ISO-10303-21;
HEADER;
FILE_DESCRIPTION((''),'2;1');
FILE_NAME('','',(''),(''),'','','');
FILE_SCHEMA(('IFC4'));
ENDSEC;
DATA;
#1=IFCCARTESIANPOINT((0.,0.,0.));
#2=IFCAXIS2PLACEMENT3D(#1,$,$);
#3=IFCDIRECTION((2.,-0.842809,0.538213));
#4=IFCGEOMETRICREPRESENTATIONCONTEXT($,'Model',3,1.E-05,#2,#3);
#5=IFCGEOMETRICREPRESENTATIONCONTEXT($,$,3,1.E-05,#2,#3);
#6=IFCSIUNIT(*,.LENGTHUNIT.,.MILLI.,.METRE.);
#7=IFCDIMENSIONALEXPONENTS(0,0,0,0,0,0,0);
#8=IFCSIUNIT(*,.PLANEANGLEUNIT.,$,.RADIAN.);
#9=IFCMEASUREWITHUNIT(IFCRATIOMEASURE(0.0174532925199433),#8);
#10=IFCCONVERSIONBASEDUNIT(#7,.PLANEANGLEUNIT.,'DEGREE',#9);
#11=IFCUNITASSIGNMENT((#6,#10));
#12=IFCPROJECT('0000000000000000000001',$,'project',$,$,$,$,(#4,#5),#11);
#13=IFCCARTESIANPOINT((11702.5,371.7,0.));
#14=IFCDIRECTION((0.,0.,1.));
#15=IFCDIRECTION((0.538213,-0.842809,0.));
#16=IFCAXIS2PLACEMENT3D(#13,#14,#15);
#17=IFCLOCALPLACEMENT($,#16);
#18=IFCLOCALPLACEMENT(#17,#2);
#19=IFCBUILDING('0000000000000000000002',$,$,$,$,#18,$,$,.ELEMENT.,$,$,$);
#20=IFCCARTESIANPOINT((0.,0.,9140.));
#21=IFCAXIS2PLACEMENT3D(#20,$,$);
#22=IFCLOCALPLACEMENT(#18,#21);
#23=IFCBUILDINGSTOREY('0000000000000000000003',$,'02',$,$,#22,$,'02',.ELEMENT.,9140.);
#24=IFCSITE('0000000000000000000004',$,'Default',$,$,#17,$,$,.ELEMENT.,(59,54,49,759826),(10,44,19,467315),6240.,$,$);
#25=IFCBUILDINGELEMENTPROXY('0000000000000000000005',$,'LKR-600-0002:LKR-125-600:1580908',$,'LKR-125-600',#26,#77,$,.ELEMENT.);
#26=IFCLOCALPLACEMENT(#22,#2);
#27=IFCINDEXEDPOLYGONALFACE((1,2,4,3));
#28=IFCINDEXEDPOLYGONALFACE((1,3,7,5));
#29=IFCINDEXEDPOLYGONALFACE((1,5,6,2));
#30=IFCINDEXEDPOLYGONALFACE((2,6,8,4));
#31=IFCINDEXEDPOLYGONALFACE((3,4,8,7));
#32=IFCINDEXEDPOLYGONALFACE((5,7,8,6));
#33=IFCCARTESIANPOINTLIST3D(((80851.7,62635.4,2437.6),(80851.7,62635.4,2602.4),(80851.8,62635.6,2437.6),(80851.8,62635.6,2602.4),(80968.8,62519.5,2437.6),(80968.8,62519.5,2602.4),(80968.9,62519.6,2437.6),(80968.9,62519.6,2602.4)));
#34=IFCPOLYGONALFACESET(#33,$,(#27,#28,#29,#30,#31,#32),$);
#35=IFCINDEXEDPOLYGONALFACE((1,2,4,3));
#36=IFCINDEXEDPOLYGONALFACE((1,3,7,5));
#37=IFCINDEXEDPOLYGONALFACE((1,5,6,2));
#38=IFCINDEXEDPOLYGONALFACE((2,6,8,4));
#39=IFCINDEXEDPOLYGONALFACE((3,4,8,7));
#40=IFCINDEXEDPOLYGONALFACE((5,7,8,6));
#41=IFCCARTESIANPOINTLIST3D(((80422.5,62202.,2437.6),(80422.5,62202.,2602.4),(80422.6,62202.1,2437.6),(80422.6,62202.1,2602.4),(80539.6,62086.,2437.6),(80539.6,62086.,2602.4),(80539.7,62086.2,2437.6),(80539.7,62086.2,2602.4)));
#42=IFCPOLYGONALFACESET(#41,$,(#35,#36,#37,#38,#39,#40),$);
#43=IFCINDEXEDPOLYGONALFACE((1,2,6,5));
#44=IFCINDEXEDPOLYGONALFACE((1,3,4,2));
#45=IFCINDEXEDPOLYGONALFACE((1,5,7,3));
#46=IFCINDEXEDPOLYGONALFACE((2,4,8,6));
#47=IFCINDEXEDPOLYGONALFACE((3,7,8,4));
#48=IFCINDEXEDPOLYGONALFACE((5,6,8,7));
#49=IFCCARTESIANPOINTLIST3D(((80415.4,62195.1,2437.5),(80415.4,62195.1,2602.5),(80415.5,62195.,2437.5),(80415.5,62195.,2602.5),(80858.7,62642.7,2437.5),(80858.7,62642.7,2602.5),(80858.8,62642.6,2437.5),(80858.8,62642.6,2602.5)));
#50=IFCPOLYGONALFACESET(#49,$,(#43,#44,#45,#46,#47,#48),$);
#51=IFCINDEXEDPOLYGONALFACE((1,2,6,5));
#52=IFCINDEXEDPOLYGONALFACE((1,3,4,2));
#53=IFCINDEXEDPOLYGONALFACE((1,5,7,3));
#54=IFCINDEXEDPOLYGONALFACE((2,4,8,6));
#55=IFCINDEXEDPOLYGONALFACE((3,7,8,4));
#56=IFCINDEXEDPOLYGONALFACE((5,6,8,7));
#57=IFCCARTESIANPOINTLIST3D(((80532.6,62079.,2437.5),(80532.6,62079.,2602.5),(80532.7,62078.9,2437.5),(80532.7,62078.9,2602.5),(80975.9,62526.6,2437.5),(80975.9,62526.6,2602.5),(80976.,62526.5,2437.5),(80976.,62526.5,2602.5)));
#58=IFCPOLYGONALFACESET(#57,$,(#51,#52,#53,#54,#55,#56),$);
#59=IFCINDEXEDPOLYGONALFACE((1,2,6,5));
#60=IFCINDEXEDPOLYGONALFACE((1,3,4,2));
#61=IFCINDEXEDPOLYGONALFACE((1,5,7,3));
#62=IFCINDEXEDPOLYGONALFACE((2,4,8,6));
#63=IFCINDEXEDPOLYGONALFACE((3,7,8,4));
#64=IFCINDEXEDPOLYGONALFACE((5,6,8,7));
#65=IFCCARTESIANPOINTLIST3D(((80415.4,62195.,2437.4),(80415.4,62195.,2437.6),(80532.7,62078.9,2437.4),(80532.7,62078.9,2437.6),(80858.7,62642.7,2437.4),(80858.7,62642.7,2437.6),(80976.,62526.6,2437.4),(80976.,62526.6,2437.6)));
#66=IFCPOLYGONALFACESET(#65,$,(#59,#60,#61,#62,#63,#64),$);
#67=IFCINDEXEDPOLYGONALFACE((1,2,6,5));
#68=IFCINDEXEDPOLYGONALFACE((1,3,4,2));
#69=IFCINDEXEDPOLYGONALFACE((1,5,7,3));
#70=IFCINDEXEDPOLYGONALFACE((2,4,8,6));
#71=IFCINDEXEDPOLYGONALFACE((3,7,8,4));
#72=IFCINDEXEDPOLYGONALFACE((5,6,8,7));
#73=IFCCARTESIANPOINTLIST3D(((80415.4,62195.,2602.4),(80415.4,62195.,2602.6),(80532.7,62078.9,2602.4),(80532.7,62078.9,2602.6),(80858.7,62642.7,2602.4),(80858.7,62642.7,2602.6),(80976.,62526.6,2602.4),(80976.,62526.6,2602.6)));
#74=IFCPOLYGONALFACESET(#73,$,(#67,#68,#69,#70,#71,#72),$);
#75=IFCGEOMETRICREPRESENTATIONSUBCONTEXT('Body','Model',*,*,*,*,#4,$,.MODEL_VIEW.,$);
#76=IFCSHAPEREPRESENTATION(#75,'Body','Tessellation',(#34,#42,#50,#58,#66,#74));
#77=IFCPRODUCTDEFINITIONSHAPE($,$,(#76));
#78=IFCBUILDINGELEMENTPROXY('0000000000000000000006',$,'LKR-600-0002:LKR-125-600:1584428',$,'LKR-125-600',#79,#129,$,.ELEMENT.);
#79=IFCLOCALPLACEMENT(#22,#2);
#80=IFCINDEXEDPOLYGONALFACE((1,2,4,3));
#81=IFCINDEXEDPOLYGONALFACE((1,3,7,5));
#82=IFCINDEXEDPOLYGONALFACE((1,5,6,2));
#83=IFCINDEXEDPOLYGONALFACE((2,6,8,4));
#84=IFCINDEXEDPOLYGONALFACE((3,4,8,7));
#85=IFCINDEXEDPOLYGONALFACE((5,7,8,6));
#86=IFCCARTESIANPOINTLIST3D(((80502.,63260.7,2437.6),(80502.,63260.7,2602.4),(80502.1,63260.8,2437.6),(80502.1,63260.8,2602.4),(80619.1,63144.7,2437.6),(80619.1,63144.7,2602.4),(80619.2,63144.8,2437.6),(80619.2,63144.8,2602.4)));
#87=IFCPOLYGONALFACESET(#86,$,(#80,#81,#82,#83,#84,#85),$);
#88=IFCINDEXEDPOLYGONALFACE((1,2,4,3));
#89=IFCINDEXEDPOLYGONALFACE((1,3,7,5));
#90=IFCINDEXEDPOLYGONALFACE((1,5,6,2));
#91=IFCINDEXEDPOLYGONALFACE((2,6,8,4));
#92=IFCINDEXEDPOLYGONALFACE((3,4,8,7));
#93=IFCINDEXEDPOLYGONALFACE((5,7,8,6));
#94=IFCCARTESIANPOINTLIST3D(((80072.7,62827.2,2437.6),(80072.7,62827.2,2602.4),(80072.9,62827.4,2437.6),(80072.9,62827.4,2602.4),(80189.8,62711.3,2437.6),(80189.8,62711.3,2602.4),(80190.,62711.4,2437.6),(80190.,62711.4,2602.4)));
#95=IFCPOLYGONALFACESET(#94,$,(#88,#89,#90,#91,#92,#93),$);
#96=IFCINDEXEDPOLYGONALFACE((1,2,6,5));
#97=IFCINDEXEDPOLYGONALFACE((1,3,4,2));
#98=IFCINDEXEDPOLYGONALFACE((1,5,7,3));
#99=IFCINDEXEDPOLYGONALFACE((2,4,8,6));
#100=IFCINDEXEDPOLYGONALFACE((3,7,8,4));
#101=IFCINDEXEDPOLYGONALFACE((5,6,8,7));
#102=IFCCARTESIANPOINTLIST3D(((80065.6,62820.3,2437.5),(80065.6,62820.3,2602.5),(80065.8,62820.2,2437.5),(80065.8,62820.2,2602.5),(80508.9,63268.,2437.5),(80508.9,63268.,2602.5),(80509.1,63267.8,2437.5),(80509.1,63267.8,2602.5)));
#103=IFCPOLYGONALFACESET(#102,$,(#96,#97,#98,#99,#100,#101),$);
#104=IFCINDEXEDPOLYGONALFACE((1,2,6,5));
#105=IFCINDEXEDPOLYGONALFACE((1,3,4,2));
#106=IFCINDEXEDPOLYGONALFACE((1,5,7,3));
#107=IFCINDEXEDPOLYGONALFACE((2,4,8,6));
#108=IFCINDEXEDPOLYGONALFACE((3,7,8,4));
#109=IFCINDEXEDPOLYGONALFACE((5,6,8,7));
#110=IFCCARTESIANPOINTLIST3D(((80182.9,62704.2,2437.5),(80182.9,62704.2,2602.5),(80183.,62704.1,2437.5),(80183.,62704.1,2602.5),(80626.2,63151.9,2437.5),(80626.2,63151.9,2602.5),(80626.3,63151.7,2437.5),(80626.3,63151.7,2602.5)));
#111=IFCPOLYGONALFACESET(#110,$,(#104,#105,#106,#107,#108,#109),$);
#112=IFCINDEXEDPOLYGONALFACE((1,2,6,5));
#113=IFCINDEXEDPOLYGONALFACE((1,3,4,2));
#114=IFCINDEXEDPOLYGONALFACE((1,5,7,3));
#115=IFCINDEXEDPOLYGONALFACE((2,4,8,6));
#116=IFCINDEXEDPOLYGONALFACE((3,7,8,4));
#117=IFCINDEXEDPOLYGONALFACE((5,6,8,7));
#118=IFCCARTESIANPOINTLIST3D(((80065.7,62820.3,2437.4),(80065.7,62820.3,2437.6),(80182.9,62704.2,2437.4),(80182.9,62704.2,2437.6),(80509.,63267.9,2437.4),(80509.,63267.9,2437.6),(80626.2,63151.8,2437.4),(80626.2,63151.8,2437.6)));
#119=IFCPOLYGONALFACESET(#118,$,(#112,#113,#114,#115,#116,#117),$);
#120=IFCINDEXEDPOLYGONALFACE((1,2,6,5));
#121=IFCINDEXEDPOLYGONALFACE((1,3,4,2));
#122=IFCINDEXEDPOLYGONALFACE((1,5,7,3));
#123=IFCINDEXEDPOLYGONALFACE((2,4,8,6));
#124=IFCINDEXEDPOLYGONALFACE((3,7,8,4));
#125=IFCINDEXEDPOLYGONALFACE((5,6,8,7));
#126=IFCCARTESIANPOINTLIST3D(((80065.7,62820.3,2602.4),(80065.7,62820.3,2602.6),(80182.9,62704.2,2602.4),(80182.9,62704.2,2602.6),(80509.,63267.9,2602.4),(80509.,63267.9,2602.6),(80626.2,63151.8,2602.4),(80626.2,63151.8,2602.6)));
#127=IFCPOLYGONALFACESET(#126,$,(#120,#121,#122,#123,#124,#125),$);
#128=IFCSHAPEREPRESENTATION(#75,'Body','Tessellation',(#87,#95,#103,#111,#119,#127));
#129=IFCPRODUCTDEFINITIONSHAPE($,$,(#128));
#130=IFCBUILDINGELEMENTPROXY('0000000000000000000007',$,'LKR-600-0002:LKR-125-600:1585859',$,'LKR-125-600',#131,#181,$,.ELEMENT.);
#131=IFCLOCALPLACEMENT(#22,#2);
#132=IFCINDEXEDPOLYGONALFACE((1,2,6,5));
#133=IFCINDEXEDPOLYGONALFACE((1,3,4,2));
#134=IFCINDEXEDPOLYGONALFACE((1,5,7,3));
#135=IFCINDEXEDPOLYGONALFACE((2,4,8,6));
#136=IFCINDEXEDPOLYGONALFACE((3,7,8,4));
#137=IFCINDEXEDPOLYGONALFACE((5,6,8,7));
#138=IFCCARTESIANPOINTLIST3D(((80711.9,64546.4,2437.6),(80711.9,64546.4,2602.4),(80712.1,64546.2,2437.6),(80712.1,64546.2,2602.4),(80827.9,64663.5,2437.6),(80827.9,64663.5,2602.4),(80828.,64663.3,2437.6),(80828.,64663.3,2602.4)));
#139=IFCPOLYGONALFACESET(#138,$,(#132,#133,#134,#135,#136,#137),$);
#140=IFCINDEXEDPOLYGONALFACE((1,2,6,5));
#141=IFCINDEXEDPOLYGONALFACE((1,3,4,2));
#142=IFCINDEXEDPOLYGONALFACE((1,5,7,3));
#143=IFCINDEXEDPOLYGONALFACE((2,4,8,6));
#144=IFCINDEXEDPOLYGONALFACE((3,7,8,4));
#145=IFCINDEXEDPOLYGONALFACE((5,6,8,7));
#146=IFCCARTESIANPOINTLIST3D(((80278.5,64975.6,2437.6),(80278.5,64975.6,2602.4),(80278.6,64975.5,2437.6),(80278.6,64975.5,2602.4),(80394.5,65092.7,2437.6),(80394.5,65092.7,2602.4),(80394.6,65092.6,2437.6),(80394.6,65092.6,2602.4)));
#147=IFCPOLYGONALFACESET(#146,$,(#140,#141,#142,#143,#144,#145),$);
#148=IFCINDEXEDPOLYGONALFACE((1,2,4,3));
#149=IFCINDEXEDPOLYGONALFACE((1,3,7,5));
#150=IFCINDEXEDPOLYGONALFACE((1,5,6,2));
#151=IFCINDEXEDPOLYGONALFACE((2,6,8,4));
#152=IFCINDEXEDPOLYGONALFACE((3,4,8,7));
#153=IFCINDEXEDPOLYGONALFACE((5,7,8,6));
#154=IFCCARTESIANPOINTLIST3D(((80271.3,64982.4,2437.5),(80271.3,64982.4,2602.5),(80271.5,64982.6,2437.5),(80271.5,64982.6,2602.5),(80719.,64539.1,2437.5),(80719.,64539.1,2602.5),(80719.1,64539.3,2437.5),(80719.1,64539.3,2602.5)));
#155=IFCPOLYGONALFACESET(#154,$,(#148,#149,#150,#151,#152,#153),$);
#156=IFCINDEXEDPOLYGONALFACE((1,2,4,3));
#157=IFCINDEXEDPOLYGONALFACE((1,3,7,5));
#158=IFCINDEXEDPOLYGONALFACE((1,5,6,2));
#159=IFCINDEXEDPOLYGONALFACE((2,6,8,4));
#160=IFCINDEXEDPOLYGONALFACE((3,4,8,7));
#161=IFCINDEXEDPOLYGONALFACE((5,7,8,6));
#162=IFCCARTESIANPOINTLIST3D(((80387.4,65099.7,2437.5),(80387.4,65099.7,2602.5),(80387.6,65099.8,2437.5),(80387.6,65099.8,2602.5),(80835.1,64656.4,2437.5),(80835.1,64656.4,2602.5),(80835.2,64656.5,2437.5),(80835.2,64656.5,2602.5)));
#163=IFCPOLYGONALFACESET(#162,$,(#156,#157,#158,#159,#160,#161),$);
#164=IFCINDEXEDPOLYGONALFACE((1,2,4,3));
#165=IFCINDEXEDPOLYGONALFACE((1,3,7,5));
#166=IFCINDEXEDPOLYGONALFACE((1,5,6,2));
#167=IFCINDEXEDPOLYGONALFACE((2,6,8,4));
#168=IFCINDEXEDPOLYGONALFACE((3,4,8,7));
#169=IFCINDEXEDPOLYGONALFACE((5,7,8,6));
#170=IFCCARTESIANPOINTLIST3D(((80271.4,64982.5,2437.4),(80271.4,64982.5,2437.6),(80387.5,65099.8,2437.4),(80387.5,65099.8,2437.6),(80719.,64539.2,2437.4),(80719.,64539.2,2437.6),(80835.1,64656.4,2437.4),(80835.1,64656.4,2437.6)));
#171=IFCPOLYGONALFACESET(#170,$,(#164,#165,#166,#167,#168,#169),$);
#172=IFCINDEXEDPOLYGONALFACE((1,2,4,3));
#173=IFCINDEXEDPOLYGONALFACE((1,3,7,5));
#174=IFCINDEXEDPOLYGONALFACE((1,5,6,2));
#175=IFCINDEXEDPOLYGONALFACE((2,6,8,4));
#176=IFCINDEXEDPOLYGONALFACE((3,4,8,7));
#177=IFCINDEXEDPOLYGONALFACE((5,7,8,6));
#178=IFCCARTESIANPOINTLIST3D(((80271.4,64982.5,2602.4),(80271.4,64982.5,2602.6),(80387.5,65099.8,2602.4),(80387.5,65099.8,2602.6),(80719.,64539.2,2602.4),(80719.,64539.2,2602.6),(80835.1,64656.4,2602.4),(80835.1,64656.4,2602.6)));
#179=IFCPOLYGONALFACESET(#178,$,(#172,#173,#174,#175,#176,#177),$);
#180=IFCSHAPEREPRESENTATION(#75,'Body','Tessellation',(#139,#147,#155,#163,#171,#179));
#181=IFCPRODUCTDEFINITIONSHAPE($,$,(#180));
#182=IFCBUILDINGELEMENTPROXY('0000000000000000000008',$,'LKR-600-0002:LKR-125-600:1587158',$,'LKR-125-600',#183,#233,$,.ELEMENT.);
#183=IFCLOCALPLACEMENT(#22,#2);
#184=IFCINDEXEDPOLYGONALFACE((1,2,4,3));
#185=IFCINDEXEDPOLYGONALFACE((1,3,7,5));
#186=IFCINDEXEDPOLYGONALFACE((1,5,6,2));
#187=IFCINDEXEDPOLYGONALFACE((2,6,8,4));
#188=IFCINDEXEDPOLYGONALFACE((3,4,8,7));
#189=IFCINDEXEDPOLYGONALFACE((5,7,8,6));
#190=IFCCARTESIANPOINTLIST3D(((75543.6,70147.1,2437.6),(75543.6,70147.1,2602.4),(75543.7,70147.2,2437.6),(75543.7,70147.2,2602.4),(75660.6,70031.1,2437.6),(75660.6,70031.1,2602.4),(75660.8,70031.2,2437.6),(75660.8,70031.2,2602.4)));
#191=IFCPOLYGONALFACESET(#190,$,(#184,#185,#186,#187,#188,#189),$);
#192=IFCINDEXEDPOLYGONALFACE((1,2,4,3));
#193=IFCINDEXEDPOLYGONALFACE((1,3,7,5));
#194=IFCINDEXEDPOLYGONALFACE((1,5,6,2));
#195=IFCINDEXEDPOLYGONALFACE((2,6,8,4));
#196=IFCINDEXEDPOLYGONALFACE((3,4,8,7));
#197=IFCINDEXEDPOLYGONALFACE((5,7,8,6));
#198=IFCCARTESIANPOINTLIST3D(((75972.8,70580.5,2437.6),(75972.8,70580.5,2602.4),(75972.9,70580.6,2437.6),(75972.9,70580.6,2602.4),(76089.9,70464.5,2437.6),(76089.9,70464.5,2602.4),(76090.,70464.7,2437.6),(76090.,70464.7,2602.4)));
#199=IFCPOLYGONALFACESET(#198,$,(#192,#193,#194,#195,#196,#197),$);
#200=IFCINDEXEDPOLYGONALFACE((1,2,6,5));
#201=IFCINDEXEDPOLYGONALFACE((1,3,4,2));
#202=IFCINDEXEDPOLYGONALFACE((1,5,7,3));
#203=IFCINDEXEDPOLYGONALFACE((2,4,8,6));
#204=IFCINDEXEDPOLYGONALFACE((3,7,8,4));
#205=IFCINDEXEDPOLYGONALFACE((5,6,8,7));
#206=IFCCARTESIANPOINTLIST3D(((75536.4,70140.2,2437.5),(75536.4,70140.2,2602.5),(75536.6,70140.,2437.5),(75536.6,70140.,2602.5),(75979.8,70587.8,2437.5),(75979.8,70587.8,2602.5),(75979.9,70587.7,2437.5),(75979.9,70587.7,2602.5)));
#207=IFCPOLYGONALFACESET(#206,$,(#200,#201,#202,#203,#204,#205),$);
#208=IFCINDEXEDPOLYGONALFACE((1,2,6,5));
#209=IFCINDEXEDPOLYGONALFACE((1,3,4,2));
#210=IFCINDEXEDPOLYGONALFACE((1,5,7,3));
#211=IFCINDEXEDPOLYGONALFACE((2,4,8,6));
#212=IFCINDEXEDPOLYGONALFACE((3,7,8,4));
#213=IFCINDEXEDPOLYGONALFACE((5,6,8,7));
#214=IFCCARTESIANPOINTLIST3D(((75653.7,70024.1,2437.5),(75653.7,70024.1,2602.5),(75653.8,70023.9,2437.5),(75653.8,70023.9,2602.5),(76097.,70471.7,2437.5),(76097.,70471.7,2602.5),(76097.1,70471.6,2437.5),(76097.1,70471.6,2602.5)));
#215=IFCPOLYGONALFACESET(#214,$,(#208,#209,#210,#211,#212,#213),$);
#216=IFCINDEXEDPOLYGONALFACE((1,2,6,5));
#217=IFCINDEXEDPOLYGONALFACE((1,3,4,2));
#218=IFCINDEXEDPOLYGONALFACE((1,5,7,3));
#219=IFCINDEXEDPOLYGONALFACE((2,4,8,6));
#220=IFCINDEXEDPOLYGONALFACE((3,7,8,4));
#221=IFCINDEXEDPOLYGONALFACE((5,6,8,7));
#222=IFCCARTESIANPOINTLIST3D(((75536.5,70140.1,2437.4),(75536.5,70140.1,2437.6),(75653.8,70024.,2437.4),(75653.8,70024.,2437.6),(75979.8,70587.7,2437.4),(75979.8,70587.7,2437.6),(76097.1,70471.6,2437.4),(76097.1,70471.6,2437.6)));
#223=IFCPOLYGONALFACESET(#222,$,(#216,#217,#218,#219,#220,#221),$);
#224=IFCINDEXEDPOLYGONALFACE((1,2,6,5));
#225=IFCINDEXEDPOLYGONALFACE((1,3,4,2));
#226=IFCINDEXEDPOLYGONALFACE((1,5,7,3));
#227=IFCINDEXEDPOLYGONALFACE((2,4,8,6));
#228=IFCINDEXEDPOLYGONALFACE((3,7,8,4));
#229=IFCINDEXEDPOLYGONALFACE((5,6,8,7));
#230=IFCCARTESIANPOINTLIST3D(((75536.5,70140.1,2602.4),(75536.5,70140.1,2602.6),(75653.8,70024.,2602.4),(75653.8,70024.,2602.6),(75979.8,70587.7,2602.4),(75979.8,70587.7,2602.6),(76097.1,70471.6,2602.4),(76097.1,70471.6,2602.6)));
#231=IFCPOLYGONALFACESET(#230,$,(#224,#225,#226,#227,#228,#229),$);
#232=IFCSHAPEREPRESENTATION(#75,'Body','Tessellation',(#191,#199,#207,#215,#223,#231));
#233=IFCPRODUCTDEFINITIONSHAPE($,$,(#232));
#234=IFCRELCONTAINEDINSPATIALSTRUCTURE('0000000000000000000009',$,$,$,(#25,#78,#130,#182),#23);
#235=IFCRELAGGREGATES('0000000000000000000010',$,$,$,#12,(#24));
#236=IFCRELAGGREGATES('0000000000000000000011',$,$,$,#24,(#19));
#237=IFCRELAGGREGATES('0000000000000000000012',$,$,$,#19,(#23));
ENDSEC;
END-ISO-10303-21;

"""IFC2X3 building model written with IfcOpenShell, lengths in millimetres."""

from ifc_helpers import new_model, entity, si_unit, converted_unit, direction, frame, frame_2d, origin, place, context, subcontext, project, spatial, rectangle, extrude, source, transform, mapped, element, save


model = new_model("IFC2X3")

# Units and contexts
model_context = context("Model", 3, precision=1e-05, world=origin(), true_north=direction((2.0, -0.842809, 0.538213)))
context_of_model = context(None, 3, precision=1e-05, world=origin(), true_north=direction((2.0, -0.842809, 0.538213)))
body_context = subcontext(model_context, "Body", "Model", "MODEL_VIEW")
ifc_project = project(units=[si_unit("LENGTHUNIT", "METRE", prefix="MILLI"), converted_unit("PLANEANGLEUNIT", "DEGREE", entity("IfcRatioMeasure", 0.0174532925199433), si_unit("PLANEANGLEUNIT", "RADIAN"), dimensions=[0, 0, 0, 0, 0, 0, 0])], contexts=[model_context, context_of_model])

# Site, building, storey
site_placement = place(None, frame((11702.5, 371.7, 0.0), z_axis=(0.0, 0.0, 1.0), x_axis=(0.538213, -0.842809, 0.0)))
site = spatial("IfcSite", under=ifc_project, at=site_placement, Name="Default", CompositionType="ELEMENT", RefLatitude=(59, 54, 49, 759826), RefLongitude=(10, 44, 19, 467315), RefElevation=6240.0)
building_placement = place(site_placement, origin())
building = spatial("IfcBuilding", under=site, at=building_placement, CompositionType="ELEMENT")
storey_placement = place(building_placement, frame((0.0, 0.0, 9140.0)))
storey = spatial("IfcBuildingStorey", under=building, at=storey_placement, Name="02", LongName="02", CompositionType="ELEMENT", Elevation=9140.0)

# Building element proxies
shared_shape_1 = source(origin(), body_context, "Body", "SweptSolid", [
    extrude(rectangle(XDim=0.2, YDim=164.8, at=frame_2d((0.0, 0.0), x_axis=(1.0, 0.0))), frame((305.0, 0.0, -82.4)), (0.0, 0.0, 1.0), 164.8),
    extrude(rectangle(XDim=0.2, YDim=164.8, at=frame_2d((0.0, 0.0), x_axis=(1.0, 0.0))), frame((-305.0, 0.0, -82.4)), (0.0, 0.0, 1.0), 164.8),
    extrude(rectangle(XDim=0.2, YDim=630.0, at=frame_2d((0.0, 0.0), x_axis=(1.0, 0.0))), frame((0.0, 82.5, -82.5), z_axis=(0.0, 0.0, 1.0), x_axis=(0.0, 1.0, 0.0)), (0.0, 0.0, 1.0), 165.0),
    extrude(rectangle(XDim=0.2, YDim=630.0, at=frame_2d((0.0, 0.0), x_axis=(1.0, 0.0))), frame((0.0, -82.5, -82.5), z_axis=(0.0, 0.0, 1.0), x_axis=(0.0, 1.0, 0.0)), (0.0, 0.0, 1.0), 165.0),
    extrude(rectangle(XDim=165.0, YDim=630.0, at=frame_2d((0.0, 0.0), x_axis=(1.0, 0.0))), frame((0.0, 0.0, -82.6), z_axis=(0.0, 0.0, 1.0), x_axis=(0.0, -1.0, 0.0)), (0.0, 0.0, 1.0), 0.2),
    extrude(rectangle(XDim=165.0, YDim=630.0, at=frame_2d((0.0, 0.0), x_axis=(1.0, 0.0))), frame((0.0, 0.0, 82.4), z_axis=(0.0, 0.0, 1.0), x_axis=(0.0, -1.0, 0.0)), (0.0, 0.0, 1.0), 0.2),
])
for number, where, z_axis, x_axis, name in (
    (1, (80695.7, 62360.8, 2520.0), (0.0, 0.0, 1.0), (0.703664, 0.710533, 0.0), "LKR-600-0002:LKR-125-600:1580908"),
    (2, (80346.0, 62986.0, 2520.0), (0.0, 0.0, 1.0), (0.703669, 0.710528, 0.0), "LKR-600-0002:LKR-125-600:1584428"),
):
    element("IfcBuildingElementProxy", number, at=place(storey_placement, frame(where, z_axis=z_axis, x_axis=x_axis)), inside=storey, Name=name, ObjectType="LKR-125-600", CompositionType="ELEMENT", context=body_context, shape_type="MappedRepresentation", body=[
        mapped(shared_shape_1, transform((0.0, 0.0, 0.0), scale=1.0)),
    ])
shared_shape_2 = source(origin(), body_context, "Body", "SweptSolid", [
    extrude(rectangle(XDim=164.8, YDim=0.2, at=frame_2d((0.0, 0.0), x_axis=(1.0, 0.0))), frame((305.0, 0.0, -82.4), z_axis=(0.0, 0.0, 1.0), x_axis=(0.0, -1.0, 0.0)), (0.0, 0.0, 1.0), 164.8),
    extrude(rectangle(XDim=164.8, YDim=0.2, at=frame_2d((0.0, 0.0), x_axis=(1.0, 0.0))), frame((-305.0, 0.0, -82.4), z_axis=(0.0, 0.0, 1.0), x_axis=(0.0, -1.0, 0.0)), (0.0, 0.0, 1.0), 164.8),
    extrude(rectangle(XDim=630.0, YDim=0.2, at=frame_2d((0.0, 0.0), x_axis=(1.0, 0.0))), frame((0.0, -82.5, -82.5), z_axis=(0.0, 0.0, 1.0), x_axis=(-1.0, 0.0, 0.0)), (0.0, 0.0, 1.0), 165.0),
    extrude(rectangle(XDim=630.0, YDim=0.2, at=frame_2d((0.0, 0.0), x_axis=(1.0, 0.0))), frame((0.0, 82.5, -82.5), z_axis=(0.0, 0.0, 1.0), x_axis=(-1.0, 0.0, 0.0)), (0.0, 0.0, 1.0), 165.0),
    extrude(rectangle(XDim=630.0, YDim=165.0, at=frame_2d((0.0, 0.0), x_axis=(1.0, 0.0))), frame((0.0, 0.0, -82.6)), (0.0, 0.0, 1.0), 0.2),
    extrude(rectangle(XDim=630.0, YDim=165.0, at=frame_2d((0.0, 0.0), x_axis=(1.0, 0.0))), frame((0.0, 0.0, 82.4)), (0.0, 0.0, 1.0), 0.2),
])
for number, where, z_axis, x_axis, name in (
    (3, (80553.3, 64819.5, 2520.0), (0.0, 0.0, 1.0), (0.710528, -0.703669, 0.0), "LKR-600-0002:LKR-125-600:1585859"),
    (4, (75816.8, 70305.9, 2520.0), (0.0, 0.0, 1.0), (-0.703669, -0.710528, 0.0), "LKR-600-0002:LKR-125-600:1587158"),
):
    element("IfcBuildingElementProxy", number, at=place(storey_placement, frame(where, z_axis=z_axis, x_axis=x_axis)), inside=storey, Name=name, ObjectType="LKR-125-600", CompositionType="ELEMENT", context=body_context, shape_type="MappedRepresentation", body=[
        mapped(shared_shape_2, transform((0.0, 0.0, 0.0), scale=1.0)),
    ])

save(model, "model.ifc")
